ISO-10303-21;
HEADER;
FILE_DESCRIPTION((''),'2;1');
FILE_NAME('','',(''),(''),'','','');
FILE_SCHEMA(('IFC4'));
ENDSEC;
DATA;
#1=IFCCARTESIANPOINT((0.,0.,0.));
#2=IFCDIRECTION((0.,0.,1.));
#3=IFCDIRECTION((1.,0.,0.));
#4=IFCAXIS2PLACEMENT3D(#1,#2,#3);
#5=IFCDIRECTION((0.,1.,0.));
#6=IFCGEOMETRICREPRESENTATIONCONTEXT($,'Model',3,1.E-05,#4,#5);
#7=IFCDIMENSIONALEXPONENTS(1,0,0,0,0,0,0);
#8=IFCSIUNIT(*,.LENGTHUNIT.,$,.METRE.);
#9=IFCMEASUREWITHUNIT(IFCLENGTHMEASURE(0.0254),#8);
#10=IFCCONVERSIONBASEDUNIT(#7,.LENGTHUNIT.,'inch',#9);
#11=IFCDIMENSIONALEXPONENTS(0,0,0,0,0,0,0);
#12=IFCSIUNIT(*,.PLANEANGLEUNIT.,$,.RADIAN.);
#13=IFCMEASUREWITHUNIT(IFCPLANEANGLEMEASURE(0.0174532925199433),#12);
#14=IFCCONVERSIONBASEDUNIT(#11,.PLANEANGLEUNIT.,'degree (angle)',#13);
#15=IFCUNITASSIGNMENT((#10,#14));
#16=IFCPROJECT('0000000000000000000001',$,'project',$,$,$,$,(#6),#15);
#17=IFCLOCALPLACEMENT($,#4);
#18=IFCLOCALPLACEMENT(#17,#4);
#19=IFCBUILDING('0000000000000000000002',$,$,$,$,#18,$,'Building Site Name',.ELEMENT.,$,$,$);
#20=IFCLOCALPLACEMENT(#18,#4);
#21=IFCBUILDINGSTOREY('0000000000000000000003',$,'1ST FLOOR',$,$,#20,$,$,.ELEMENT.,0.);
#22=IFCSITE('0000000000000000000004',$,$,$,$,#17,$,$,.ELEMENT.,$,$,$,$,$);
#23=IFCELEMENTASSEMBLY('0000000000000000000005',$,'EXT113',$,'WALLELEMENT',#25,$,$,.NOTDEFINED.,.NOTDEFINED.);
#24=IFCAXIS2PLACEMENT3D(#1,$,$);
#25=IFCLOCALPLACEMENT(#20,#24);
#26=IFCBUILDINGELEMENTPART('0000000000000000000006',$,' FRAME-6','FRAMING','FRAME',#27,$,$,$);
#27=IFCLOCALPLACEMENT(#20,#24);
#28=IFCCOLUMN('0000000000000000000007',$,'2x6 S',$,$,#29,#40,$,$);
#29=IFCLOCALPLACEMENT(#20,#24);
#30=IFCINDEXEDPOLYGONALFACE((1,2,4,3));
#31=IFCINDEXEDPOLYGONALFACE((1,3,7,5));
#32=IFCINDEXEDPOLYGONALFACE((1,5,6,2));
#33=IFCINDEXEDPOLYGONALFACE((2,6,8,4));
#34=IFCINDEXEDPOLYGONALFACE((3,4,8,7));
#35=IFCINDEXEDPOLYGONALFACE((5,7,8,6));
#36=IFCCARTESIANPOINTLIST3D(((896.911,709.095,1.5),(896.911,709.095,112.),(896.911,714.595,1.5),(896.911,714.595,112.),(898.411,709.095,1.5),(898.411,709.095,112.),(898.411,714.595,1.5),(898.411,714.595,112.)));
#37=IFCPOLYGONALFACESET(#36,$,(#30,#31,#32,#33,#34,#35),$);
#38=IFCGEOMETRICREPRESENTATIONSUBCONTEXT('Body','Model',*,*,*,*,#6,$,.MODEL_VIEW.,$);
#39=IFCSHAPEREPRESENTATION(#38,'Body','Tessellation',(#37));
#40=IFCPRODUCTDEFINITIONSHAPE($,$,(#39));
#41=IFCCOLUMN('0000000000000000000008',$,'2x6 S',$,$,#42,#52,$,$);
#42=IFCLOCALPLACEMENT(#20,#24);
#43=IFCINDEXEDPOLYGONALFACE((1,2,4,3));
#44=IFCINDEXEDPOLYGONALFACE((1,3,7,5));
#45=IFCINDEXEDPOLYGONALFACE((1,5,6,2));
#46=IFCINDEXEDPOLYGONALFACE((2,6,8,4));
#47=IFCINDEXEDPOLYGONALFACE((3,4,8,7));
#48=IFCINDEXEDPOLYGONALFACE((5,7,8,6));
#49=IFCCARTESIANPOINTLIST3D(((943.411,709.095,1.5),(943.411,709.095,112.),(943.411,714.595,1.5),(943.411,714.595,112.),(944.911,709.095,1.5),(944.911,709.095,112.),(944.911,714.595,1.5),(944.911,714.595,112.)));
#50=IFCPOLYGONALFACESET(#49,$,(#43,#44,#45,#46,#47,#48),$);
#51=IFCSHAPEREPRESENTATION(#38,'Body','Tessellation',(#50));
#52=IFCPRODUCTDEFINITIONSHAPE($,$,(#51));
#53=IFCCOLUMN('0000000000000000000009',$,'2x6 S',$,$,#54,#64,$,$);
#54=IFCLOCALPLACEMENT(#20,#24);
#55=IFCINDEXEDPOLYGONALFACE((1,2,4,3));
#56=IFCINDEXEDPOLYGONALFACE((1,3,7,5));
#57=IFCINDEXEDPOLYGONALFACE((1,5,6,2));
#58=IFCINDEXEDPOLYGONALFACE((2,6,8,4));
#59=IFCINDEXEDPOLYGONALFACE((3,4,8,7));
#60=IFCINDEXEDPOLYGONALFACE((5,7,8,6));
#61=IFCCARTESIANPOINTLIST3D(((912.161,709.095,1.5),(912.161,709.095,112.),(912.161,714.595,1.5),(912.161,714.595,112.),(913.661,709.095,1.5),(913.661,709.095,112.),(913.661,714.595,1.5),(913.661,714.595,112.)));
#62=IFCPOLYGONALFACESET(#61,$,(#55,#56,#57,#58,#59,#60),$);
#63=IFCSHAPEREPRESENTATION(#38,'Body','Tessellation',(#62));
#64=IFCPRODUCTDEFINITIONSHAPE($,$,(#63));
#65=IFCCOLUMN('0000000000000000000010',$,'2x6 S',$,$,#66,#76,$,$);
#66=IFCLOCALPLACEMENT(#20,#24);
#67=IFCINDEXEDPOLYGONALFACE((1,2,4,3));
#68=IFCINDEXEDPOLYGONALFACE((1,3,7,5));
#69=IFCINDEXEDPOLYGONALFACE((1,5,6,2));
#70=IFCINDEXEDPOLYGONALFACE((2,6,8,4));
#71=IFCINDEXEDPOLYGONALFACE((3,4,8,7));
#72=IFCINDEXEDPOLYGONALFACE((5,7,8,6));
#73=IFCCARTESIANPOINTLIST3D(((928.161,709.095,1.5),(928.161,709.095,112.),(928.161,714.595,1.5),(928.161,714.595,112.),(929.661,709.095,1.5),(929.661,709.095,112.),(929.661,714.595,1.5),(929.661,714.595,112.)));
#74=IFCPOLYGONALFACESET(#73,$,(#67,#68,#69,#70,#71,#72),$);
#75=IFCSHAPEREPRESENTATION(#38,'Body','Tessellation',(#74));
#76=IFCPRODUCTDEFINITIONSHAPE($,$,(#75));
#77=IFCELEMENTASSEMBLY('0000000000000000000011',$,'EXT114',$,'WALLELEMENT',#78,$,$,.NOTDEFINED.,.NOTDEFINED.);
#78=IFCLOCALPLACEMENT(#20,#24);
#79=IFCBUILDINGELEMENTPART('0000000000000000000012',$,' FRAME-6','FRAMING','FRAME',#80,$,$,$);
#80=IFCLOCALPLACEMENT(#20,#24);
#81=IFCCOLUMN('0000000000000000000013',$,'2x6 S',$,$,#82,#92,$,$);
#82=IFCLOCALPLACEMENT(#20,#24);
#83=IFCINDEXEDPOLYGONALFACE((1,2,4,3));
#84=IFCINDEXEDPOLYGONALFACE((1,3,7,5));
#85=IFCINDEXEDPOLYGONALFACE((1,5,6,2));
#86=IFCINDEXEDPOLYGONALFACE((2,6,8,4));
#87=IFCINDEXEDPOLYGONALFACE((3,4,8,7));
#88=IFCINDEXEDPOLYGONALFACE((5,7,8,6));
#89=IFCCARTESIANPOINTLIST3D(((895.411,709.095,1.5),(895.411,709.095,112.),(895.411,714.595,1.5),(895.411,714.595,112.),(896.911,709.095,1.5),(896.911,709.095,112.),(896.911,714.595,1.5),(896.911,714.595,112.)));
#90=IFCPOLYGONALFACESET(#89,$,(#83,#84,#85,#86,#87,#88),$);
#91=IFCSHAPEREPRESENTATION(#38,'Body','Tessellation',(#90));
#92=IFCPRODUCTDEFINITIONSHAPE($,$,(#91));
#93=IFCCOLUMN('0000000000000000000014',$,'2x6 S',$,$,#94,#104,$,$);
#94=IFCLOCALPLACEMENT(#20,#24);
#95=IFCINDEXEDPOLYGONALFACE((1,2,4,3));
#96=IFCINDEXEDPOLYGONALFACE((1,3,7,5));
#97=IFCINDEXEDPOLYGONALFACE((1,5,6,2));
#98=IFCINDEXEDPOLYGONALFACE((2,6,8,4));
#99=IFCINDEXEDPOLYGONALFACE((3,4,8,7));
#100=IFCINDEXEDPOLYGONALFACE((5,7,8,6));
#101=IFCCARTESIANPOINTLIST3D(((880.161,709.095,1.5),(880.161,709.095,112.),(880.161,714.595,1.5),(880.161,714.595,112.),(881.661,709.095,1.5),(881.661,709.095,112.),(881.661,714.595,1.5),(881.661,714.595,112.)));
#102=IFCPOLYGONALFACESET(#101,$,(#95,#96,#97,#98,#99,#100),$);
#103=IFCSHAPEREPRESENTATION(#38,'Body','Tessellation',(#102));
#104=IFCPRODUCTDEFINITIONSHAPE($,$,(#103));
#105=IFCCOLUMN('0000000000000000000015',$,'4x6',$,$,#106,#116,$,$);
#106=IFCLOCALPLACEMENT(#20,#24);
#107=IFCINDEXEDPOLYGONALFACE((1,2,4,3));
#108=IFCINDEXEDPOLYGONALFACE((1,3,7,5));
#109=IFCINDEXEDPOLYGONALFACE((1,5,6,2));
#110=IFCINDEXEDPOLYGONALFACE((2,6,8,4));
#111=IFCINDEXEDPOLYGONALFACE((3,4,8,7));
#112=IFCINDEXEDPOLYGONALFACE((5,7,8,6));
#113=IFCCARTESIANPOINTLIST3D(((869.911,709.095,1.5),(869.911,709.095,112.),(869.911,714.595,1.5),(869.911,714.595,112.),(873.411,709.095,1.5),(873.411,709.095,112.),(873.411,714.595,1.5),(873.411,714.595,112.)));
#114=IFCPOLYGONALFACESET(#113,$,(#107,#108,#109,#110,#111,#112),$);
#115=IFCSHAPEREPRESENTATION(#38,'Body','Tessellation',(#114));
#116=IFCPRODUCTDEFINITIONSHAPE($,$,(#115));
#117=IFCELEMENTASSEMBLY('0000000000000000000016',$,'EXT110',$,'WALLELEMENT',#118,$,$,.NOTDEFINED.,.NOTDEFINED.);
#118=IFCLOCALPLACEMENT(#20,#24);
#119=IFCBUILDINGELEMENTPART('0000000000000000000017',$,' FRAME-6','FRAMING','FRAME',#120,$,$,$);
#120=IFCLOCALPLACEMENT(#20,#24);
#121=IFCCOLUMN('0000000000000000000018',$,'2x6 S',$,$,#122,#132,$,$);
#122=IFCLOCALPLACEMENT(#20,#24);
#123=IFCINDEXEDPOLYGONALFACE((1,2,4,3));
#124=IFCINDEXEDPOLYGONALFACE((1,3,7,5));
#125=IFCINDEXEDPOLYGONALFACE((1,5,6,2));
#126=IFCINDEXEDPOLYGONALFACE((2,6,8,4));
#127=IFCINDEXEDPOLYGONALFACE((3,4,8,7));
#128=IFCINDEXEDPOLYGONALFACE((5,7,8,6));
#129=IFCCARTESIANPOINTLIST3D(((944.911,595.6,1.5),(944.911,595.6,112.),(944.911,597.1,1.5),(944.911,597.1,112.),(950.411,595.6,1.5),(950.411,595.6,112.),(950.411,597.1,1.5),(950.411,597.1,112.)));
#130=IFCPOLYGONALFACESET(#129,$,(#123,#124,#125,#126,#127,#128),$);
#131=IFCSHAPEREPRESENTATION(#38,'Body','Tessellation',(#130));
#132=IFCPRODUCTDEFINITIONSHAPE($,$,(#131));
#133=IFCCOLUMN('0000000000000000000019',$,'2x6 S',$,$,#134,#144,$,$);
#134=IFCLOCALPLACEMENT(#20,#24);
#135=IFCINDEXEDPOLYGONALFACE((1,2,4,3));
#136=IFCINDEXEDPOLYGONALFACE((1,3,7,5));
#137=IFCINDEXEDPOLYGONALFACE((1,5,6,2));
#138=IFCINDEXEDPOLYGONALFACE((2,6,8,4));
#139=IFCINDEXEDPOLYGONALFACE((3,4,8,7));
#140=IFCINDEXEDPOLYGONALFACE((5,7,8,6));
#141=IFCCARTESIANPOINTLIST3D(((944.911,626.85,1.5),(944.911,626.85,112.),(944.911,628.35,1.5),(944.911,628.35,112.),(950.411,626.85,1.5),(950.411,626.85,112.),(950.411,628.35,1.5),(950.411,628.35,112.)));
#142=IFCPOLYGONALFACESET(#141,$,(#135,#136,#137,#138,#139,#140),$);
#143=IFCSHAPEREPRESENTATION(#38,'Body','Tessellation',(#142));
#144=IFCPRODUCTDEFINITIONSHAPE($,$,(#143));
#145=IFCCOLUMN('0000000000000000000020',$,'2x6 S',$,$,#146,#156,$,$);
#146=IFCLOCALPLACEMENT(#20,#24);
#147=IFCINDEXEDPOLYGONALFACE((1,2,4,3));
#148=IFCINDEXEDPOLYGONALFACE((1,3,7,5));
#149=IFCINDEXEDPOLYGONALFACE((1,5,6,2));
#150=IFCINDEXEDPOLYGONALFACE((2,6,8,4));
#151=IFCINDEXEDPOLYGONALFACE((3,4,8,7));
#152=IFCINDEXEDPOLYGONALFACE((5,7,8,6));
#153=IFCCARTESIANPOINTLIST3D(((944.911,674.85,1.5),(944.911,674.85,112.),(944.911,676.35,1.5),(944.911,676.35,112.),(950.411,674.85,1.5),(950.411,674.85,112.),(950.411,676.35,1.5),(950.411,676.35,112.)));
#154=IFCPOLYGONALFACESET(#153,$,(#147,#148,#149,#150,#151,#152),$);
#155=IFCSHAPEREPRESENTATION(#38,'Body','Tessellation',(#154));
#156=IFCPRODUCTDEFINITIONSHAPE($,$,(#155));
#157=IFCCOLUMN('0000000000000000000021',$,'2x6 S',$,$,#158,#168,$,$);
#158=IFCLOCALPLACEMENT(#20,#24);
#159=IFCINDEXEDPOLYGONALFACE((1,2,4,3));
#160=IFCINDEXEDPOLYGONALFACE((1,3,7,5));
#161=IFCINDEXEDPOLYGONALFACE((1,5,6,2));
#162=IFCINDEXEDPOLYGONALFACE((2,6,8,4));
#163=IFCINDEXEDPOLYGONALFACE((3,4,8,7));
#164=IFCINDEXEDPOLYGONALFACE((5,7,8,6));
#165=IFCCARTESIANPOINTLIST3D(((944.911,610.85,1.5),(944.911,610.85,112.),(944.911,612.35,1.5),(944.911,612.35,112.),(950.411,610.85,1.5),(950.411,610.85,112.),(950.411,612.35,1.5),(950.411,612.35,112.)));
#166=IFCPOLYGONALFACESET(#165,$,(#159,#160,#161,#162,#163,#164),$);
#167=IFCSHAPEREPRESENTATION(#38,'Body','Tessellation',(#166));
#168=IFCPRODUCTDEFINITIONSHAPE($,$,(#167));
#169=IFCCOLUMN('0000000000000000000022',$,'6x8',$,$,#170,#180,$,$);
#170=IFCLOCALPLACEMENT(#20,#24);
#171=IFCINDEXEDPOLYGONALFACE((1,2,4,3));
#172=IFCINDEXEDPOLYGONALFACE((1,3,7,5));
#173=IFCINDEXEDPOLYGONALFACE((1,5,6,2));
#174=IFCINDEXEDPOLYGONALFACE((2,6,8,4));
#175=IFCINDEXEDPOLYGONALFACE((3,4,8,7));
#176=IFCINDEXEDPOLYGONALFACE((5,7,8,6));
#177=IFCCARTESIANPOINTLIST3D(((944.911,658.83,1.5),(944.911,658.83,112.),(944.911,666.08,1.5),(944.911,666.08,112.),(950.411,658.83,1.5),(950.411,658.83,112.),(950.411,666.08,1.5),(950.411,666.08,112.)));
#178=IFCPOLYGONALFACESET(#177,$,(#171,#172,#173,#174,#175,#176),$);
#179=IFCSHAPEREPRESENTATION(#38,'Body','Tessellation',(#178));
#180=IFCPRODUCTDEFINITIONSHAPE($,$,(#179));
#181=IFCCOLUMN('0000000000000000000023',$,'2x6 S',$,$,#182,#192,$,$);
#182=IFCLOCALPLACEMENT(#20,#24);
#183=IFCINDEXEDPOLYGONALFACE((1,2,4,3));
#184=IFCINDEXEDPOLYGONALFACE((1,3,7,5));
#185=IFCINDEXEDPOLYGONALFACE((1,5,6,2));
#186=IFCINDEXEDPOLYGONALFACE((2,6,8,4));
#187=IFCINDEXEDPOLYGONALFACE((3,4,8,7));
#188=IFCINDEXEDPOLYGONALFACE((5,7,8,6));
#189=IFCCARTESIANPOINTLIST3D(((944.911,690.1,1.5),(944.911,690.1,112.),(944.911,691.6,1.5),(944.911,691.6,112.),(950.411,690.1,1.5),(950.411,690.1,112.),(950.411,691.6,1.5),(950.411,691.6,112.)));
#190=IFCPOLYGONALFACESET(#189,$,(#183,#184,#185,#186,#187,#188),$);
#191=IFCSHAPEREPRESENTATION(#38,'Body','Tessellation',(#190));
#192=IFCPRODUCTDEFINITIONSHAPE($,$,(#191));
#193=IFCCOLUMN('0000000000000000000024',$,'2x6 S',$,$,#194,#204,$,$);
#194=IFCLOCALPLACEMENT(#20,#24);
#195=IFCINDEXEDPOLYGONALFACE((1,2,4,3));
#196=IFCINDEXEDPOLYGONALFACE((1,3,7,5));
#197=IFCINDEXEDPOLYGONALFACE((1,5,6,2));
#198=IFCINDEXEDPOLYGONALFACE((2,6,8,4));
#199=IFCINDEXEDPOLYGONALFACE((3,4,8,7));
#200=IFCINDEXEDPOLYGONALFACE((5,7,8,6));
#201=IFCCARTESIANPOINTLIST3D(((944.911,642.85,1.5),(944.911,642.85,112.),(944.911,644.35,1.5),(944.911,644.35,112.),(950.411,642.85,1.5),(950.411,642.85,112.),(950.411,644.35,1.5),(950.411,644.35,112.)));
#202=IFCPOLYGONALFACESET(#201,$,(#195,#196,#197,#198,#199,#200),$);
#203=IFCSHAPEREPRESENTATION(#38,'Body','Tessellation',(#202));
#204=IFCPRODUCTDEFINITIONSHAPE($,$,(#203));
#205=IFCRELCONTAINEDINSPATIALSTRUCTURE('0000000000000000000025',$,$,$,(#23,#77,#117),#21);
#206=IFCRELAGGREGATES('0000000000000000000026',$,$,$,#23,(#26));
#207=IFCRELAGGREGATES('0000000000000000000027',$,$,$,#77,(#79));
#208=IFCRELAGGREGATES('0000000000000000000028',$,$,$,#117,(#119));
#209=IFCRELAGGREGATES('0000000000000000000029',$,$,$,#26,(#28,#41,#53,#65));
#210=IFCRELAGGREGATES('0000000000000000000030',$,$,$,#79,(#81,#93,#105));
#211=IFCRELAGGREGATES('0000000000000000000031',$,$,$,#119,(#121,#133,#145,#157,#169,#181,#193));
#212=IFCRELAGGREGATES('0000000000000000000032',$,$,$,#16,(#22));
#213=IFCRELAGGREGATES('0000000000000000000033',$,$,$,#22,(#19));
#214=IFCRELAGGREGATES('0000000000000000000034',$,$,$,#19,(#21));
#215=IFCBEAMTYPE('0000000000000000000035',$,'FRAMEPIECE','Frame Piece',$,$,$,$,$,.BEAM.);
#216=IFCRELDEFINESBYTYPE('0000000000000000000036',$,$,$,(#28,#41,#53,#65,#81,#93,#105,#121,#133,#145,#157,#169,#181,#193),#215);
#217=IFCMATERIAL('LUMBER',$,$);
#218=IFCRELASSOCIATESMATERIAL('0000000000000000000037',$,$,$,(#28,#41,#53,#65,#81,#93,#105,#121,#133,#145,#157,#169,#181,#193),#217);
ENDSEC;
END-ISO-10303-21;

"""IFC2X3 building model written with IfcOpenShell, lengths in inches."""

from ifc_helpers import new_model, entity, si_unit, converted_unit, direction, frame, frame_2d, origin_with_axes, place, context, subcontext, project, spatial, polyline, segment, composite_curve, rectangle, outline, extrude, material, type_object, element, aggregate, save


model = new_model("IFC2X3")

# Units and contexts
model_context = context("Model", 3, precision=1e-05, world=origin_with_axes(), true_north=direction((0.0, 1.0, 0.0)))
body_context = subcontext(model_context, "Body", "Model", "MODEL_VIEW")
ifc_project = project(units=[converted_unit("LENGTHUNIT", "inch", entity("IfcLengthMeasure", 0.0254), si_unit("LENGTHUNIT", "METRE"), dimensions=[1, 0, 0, 0, 0, 0, 0]), converted_unit("PLANEANGLEUNIT", "degree (angle)", entity("IfcPlaneAngleMeasure", 0.0174532925199433), si_unit("PLANEANGLEUNIT", "RADIAN"), dimensions=[0, 0, 0, 0, 0, 0, 0])], contexts=[model_context])

# Site, building, storey
site_placement = place(None, origin_with_axes())
site = spatial("IfcSite", under=ifc_project, at=site_placement, CompositionType="ELEMENT")
building_placement = place(site_placement, origin_with_axes())
building = spatial("IfcBuilding", under=site, at=building_placement, LongName="Building Site Name", CompositionType="ELEMENT")
storey_placement = place(building_placement, origin_with_axes())
storey = spatial("IfcBuildingStorey", under=building, at=storey_placement, Name="1ST FLOOR", CompositionType="ELEMENT", Elevation=0.0)

# Element assemblies, building element parts, columns
assembly_1_placement = place(storey_placement, origin_with_axes())
assembly_1 = element("IfcElementAssembly", 1, at=assembly_1_placement, inside=storey, Name="EXT113", ObjectType="WALLELEMENT", AssemblyPlace="NOTDEFINED", PredefinedType="NOTDEFINED")
building_element_part_1 = element("IfcBuildingElementPart", 2, Name=" FRAME-6", Description="FRAMING", ObjectType="FRAME")
aggregate(assembly_1, [building_element_part_1])
ifc_material_1 = material(Name="LUMBER")
beam_type = type_object("IfcBeamType", Name="FRAMEPIECE", Description="Frame Piece", PredefinedType="BEAM")
column_1_placement = place(assembly_1_placement, frame((897.661, 711.845, 1.5), z_axis=(0.0, 0.0, 1.0), x_axis=(1.0, 0.0, 0.0)))
column_1 = element("IfcColumn", 3, at=column_1_placement, type_object=beam_type, material=ifc_material_1, Name="2x6 S", context=body_context, shape_type="SweptSolid", body=[
    extrude(rectangle(XDim=1.5, YDim=5.5, at=frame_2d((0.0, 0.0), x_axis=(-1.0, 0.0))), frame((0.0, 0.0, 0.0), z_axis=(0.0, 0.0, 1.0), x_axis=(1.0, 0.0, 0.0)), (0.0, 0.0, 1.0), 110.5),
])
column_2_placement = place(assembly_1_placement, frame((944.161, 711.845, 112.0), z_axis=(0.0, 0.0, -1.0), x_axis=(-1.0, 0.0, 0.0)))
column_2 = element("IfcColumn", 4, at=column_2_placement, type_object=beam_type, material=ifc_material_1, Name="2x6 S", context=body_context, shape_type="SweptSolid", body=[
    extrude(rectangle(XDim=1.5, YDim=5.5, at=frame_2d((0.0, 0.0), x_axis=(-1.0, 0.0))), origin_with_axes(), (0.0, 0.0, 1.0), 110.5),
])
column_3_placement = place(assembly_1_placement, frame((912.911, 711.845, 112.0), z_axis=(0.0, 0.0, -1.0), x_axis=(-1.0, 0.0, 0.0)))
column_3 = element("IfcColumn", 5, at=column_3_placement, type_object=beam_type, material=ifc_material_1, Name="2x6 S", context=body_context, shape_type="SweptSolid", body=[
    extrude(rectangle(XDim=1.5, YDim=5.5, at=frame_2d((0.0, 0.0), x_axis=(-1.0, 0.0))), origin_with_axes(), (0.0, 0.0, 1.0), 110.5),
])
column_4_placement = place(assembly_1_placement, frame((928.911, 711.845, 112.0), z_axis=(0.0, 0.0, -1.0), x_axis=(-1.0, 0.0, 0.0)))
column_4 = element("IfcColumn", 6, at=column_4_placement, type_object=beam_type, material=ifc_material_1, Name="2x6 S", context=body_context, shape_type="SweptSolid", body=[
    extrude(rectangle(XDim=1.5, YDim=5.5, at=frame_2d((0.0, 0.0), x_axis=(-1.0, 0.0))), origin_with_axes(), (0.0, 0.0, 1.0), 110.5),
])
assembly_2_placement = place(storey_placement, origin_with_axes())
assembly_2 = element("IfcElementAssembly", 7, at=assembly_2_placement, inside=storey, Name="EXT114", ObjectType="WALLELEMENT", AssemblyPlace="NOTDEFINED", PredefinedType="NOTDEFINED")
building_element_part_2 = element("IfcBuildingElementPart", 8, Name=" FRAME-6", Description="FRAMING", ObjectType="FRAME")
aggregate(assembly_2, [building_element_part_2])
column_5_placement = place(assembly_2_placement, frame((896.161, 711.845, 112.0), z_axis=(0.0, 0.0, -1.0), x_axis=(-1.0, 0.0, 0.0)))
column_5 = element("IfcColumn", 9, at=column_5_placement, type_object=beam_type, material=ifc_material_1, Name="2x6 S", context=body_context, shape_type="SweptSolid", body=[
    extrude(rectangle(XDim=1.5, YDim=5.5, at=frame_2d((0.0, 0.0), x_axis=(-1.0, 0.0))), origin_with_axes(), (0.0, 0.0, 1.0), 110.5),
])
column_6_placement = place(assembly_2_placement, frame((880.911, 711.845, 112.0), z_axis=(0.0, 0.0, -1.0), x_axis=(-1.0, 0.0, 0.0)))
column_6 = element("IfcColumn", 10, at=column_6_placement, type_object=beam_type, material=ifc_material_1, Name="2x6 S", context=body_context, shape_type="SweptSolid", body=[
    extrude(rectangle(XDim=1.5, YDim=5.5, at=frame_2d((0.0, 0.0), x_axis=(-1.0, 0.0))), origin_with_axes(), (0.0, 0.0, 1.0), 110.5),
])
column_7_placement = place(assembly_2_placement, frame((871.661, 711.845, 112.0), z_axis=(0.0, 0.0, -1.0), x_axis=(-1.0, 0.0, 0.0)))
column_7 = element("IfcColumn", 11, at=column_7_placement, type_object=beam_type, material=ifc_material_1, Name="4x6", context=body_context, shape_type="SweptSolid", body=[
    extrude(outline(composite_curve([segment(polyline([(-1.75, -2.75), (-1.75, 2.75), (1.75, 2.75), (1.75, -2.75), (-1.75, -2.75)]), True, "CONTINUOUS")], self_intersect=False)), origin_with_axes(), (0.0, 0.0, 1.0), 110.5),
])
assembly_3_placement = place(storey_placement, origin_with_axes())
assembly_3 = element("IfcElementAssembly", 12, at=assembly_3_placement, inside=storey, Name="EXT110", ObjectType="WALLELEMENT", AssemblyPlace="NOTDEFINED", PredefinedType="NOTDEFINED")
building_element_part_3 = element("IfcBuildingElementPart", 13, Name=" FRAME-6", Description="FRAMING", ObjectType="FRAME")
aggregate(assembly_3, [building_element_part_3])
column_8_placement = place(assembly_3_placement, frame((947.661, 596.35, 1.5), z_axis=(0.0, 0.0, 1.0), x_axis=(0.0, 1.0, 0.0)))
column_8 = element("IfcColumn", 14, at=column_8_placement, type_object=beam_type, material=ifc_material_1, Name="2x6 S", context=body_context, shape_type="SweptSolid", body=[
    extrude(rectangle(XDim=1.5, YDim=5.5, at=frame_2d((0.0, 0.0), x_axis=(-1.0, 0.0))), frame((0.0, 0.0, 0.0), z_axis=(0.0, 0.0, 1.0), x_axis=(1.0, 0.0, 0.0)), (0.0, 0.0, 1.0), 110.5),
])
column_9_placement = place(assembly_3_placement, frame((947.661, 627.6, 112.0), z_axis=(0.0, 0.0, -1.0), x_axis=(0.0, -1.0, 0.0)))
column_9 = element("IfcColumn", 15, at=column_9_placement, type_object=beam_type, material=ifc_material_1, Name="2x6 S", context=body_context, shape_type="SweptSolid", body=[
    extrude(rectangle(XDim=1.5, YDim=5.5, at=frame_2d((0.0, 0.0), x_axis=(-1.0, 0.0))), origin_with_axes(), (0.0, 0.0, 1.0), 110.5),
])
column_10_placement = place(assembly_3_placement, frame((947.661, 675.6, 112.0), z_axis=(0.0, 0.0, -1.0), x_axis=(0.0, -1.0, 0.0)))
column_10 = element("IfcColumn", 16, at=column_10_placement, type_object=beam_type, material=ifc_material_1, Name="2x6 S", context=body_context, shape_type="SweptSolid", body=[
    extrude(rectangle(XDim=1.5, YDim=5.5, at=frame_2d((0.0, 0.0), x_axis=(-1.0, 0.0))), origin_with_axes(), (0.0, 0.0, 1.0), 110.5),
])
column_11_placement = place(assembly_3_placement, frame((947.661, 611.6, 112.0), z_axis=(0.0, 0.0, -1.0), x_axis=(0.0, -1.0, 0.0)))
column_11 = element("IfcColumn", 17, at=column_11_placement, type_object=beam_type, material=ifc_material_1, Name="2x6 S", context=body_context, shape_type="SweptSolid", body=[
    extrude(rectangle(XDim=1.5, YDim=5.5, at=frame_2d((0.0, 0.0), x_axis=(-1.0, 0.0))), origin_with_axes(), (0.0, 0.0, 1.0), 110.5),
])
column_12_placement = place(assembly_3_placement, frame((947.661, 662.455, 112.0), z_axis=(0.0, 0.0, -1.0), x_axis=(1.0, 0.0, 0.0)))
column_12 = element("IfcColumn", 18, at=column_12_placement, type_object=beam_type, material=ifc_material_1, Name="6x8", context=body_context, shape_type="SweptSolid", body=[
    extrude(rectangle(XDim=5.5, YDim=7.25, at=frame_2d((0.0, 0.0), x_axis=(-1.0, 0.0))), origin_with_axes(), (0.0, 0.0, 1.0), 110.5),
])
column_13_placement = place(assembly_3_placement, frame((947.661, 690.85, 112.0), z_axis=(0.0, 0.0, -1.0), x_axis=(0.0, -1.0, 0.0)))
column_13 = element("IfcColumn", 19, at=column_13_placement, type_object=beam_type, material=ifc_material_1, Name="2x6 S", context=body_context, shape_type="SweptSolid", body=[
    extrude(rectangle(XDim=1.5, YDim=5.5, at=frame_2d((0.0, 0.0), x_axis=(-1.0, 0.0))), origin_with_axes(), (0.0, 0.0, 1.0), 110.5),
])
column_14_placement = place(assembly_3_placement, frame((947.661, 643.6, 112.0), z_axis=(0.0, 0.0, -1.0), x_axis=(0.0, -1.0, 0.0)))
column_14 = element("IfcColumn", 20, at=column_14_placement, type_object=beam_type, material=ifc_material_1, Name="2x6 S", context=body_context, shape_type="SweptSolid", body=[
    extrude(rectangle(XDim=1.5, YDim=5.5, at=frame_2d((0.0, 0.0), x_axis=(-1.0, 0.0))), origin_with_axes(), (0.0, 0.0, 1.0), 110.5),
])

aggregate(building_element_part_1, [column_1, column_2, column_3, column_4])
aggregate(building_element_part_2, [column_5, column_6, column_7])

aggregate(building_element_part_3, [column_8, column_9, column_10, column_11, column_12, column_13, column_14])

save(model, "model.ifc")
